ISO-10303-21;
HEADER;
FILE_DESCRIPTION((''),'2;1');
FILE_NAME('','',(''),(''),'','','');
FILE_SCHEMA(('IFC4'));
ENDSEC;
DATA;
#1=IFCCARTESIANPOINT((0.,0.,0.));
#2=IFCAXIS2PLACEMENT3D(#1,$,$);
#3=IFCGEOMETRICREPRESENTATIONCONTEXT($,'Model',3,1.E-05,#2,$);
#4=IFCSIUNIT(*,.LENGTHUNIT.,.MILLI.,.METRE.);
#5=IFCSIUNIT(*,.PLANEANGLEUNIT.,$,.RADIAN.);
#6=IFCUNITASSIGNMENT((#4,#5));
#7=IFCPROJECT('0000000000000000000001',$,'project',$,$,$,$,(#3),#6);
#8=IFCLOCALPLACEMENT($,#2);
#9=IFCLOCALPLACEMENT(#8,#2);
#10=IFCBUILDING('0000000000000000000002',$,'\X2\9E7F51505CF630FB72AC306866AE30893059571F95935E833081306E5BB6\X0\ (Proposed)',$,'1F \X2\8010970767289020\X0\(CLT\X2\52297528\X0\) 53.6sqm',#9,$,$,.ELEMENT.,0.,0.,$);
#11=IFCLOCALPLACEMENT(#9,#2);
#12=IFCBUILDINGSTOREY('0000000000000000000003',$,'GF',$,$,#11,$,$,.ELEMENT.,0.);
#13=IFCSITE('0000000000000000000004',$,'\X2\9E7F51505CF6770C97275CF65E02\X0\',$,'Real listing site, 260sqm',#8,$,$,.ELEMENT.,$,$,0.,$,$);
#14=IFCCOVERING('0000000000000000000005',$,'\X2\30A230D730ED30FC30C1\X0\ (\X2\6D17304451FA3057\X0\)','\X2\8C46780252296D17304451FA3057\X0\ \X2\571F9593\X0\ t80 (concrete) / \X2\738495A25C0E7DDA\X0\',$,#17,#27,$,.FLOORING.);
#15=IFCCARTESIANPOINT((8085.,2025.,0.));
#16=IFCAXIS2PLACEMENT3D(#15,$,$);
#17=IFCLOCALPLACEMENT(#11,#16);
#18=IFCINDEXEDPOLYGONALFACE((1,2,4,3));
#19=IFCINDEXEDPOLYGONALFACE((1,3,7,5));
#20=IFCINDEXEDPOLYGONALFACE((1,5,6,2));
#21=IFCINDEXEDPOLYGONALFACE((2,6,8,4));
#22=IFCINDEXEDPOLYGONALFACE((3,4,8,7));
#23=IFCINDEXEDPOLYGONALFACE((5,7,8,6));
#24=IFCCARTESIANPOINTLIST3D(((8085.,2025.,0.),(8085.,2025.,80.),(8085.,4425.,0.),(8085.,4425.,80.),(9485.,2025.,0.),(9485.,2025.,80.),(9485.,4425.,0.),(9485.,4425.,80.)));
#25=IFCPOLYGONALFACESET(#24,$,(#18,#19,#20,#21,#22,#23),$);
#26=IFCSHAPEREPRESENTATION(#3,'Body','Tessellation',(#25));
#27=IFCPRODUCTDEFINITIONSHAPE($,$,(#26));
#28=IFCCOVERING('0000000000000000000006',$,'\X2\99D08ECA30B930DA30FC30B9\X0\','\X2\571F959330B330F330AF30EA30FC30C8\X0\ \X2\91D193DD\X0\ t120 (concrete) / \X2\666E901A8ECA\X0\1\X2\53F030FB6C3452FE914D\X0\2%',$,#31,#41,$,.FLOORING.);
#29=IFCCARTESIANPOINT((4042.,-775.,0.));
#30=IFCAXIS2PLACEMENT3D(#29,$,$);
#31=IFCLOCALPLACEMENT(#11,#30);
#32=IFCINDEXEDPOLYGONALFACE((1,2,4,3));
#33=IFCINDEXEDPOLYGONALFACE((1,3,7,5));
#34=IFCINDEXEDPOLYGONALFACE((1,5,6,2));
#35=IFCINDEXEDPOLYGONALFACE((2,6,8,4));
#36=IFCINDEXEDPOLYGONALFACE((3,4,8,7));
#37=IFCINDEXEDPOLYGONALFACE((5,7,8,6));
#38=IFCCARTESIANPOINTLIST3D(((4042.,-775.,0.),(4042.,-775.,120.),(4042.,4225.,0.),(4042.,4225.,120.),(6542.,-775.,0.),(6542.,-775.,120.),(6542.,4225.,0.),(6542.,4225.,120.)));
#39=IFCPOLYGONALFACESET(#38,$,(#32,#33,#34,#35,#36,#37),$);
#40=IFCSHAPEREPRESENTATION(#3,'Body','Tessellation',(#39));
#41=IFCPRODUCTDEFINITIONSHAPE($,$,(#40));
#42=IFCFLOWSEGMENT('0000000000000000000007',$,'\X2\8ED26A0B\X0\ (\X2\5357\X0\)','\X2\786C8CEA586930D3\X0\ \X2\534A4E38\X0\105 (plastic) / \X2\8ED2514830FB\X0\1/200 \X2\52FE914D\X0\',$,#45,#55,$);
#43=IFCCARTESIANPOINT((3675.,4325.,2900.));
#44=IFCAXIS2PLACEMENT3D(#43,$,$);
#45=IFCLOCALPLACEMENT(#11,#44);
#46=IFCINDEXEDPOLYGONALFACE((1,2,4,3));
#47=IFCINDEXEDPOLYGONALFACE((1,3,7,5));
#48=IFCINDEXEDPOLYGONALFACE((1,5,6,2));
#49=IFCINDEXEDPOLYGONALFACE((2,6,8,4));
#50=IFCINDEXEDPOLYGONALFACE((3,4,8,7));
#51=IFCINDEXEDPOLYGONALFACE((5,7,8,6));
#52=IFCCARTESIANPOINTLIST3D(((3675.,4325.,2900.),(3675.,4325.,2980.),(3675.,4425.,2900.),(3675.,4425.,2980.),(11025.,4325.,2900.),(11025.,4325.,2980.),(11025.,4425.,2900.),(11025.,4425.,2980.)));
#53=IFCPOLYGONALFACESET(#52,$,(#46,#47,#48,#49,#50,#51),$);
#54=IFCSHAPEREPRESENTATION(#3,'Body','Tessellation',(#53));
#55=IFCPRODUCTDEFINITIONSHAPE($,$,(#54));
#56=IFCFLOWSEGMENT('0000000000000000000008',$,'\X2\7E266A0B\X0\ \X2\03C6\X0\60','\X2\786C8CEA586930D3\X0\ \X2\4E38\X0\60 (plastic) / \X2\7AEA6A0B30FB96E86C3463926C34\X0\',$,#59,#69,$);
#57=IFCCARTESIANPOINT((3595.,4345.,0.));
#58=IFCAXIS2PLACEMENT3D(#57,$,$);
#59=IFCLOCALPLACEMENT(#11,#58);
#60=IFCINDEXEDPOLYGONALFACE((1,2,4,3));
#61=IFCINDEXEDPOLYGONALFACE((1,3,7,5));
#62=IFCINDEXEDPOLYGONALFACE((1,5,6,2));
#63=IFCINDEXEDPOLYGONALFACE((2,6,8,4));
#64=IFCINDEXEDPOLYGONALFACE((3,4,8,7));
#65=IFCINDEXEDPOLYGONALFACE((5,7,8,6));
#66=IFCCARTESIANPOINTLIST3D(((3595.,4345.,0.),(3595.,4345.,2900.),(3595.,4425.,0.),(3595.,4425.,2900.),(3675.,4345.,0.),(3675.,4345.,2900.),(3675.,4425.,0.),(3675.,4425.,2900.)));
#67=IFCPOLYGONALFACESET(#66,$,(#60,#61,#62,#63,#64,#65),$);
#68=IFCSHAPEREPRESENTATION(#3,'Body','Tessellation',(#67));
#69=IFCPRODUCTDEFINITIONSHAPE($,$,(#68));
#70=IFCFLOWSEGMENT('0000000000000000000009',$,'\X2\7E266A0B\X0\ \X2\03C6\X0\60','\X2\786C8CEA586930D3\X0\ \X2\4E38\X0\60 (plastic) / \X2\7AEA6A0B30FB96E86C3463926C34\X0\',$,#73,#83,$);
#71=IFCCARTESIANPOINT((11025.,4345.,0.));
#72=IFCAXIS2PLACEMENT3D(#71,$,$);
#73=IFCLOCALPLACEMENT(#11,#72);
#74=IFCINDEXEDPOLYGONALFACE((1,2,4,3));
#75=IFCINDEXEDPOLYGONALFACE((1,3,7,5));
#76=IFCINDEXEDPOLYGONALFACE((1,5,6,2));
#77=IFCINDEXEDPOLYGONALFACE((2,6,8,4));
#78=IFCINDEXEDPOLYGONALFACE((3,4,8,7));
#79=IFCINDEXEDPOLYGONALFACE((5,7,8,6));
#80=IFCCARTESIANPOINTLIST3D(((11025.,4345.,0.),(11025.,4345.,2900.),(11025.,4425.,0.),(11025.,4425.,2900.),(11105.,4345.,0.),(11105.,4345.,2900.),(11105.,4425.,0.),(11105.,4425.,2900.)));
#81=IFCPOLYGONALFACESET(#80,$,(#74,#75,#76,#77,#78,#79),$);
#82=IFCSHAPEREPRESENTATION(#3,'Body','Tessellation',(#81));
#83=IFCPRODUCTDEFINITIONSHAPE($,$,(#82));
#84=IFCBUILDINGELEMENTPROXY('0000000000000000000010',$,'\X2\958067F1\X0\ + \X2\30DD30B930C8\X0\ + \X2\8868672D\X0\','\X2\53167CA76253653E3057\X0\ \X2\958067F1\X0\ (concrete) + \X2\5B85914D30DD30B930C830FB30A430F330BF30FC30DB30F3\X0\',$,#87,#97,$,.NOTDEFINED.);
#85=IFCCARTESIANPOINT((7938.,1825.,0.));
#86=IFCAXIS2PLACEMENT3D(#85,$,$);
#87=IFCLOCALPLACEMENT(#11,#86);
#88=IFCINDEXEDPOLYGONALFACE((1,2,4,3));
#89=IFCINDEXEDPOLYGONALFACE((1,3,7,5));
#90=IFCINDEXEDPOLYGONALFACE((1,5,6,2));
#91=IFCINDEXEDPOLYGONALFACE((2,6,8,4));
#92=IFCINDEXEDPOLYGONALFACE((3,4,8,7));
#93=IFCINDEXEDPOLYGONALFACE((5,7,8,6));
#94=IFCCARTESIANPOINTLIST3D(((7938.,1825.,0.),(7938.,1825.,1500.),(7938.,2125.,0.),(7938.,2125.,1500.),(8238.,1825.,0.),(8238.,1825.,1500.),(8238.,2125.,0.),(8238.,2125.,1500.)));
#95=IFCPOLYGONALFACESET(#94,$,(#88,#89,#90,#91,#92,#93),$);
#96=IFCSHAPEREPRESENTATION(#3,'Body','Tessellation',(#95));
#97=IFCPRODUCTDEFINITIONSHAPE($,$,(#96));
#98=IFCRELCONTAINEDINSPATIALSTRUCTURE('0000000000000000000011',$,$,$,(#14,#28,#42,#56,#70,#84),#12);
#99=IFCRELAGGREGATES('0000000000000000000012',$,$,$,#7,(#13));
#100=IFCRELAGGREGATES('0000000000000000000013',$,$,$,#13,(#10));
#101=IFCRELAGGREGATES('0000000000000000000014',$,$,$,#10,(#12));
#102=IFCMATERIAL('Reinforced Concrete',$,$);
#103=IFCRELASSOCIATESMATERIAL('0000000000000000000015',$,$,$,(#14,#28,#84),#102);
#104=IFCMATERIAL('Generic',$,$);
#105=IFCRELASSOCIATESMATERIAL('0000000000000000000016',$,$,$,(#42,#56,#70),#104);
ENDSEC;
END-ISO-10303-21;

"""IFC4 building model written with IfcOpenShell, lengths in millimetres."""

from ifc_helpers import new_model, si_unit, frame, frame_2d, origin, place, context, project, spatial, rectangle, extrude, material, element, save


model = new_model("IFC4")

# Units and contexts
model_context = context("Model", 3, precision=1e-05, world=origin())
ifc_project = project(units=[si_unit("LENGTHUNIT", "METRE", prefix="MILLI"), si_unit("PLANEANGLEUNIT", "RADIAN")], contexts=[model_context])

# Site, building, storey
site_placement = place(None, origin())
site = spatial("IfcSite", under=ifc_project, at=site_placement, Name="鹿児島県霧島市", ObjectType="Real listing site, 260sqm", CompositionType="ELEMENT", RefElevation=0.0)
building_placement = place(site_placement, origin())
building = spatial("IfcBuilding", under=site, at=building_placement, Name="鹿児島・犬と暮らす土間広めの家 (Proposed)", ObjectType="1F 耐震木造(CLT利用) 53.6sqm", CompositionType="ELEMENT", ElevationOfRefHeight=0.0, ElevationOfTerrain=0.0)
storey_placement = place(building_placement, origin())
storey = spatial("IfcBuildingStorey", under=building, at=storey_placement, Name="GF", CompositionType="ELEMENT", Elevation=0.0)

# Shared definitions
ifc_material_1 = material(Name="Reinforced Concrete")

# Coverings
ifc_material_2 = material(Name="Generic")
covering_1_placement = place(storey_placement, frame((8085.0, 2025.0, 0.0)))
element("IfcCovering", 1, at=covering_1_placement, inside=storey, material=ifc_material_1, Name="アプローチ (洗い出し)", Description="豆砂利洗い出し 土間 t80 (concrete) / 玄関導線", PredefinedType="FLOORING", context=model_context, shape_type="SweptSolid", body=[
    extrude(rectangle(XDim=1400.0, YDim=2400.0, at=frame_2d((700.0, 1200.0))), frame((8085.0, 2025.0, 0.0)), (0.0, 0.0, 1.0), 80.0),
])
covering_2_placement = place(storey_placement, frame((4042.0, -775.0, 0.0)))
element("IfcCovering", 2, at=covering_2_placement, inside=storey, material=ifc_material_1, Name="駐車スペース", Description="土間コンクリート 金鏝 t120 (concrete) / 普通車1台・水勾配2%", PredefinedType="FLOORING", context=model_context, shape_type="SweptSolid", body=[
    extrude(rectangle(XDim=2500.0, YDim=5000.0, at=frame_2d((1250.0, 2500.0))), frame((4042.0, -775.0, 0.0)), (0.0, 0.0, 1.0), 120.0),
])

# Flow segments
flow_segment_1_placement = place(storey_placement, frame((3675.0, 4325.0, 2900.0)))
element("IfcFlowSegment", 3, at=flow_segment_1_placement, inside=storey, material=ifc_material_2, Name="軒樋 (南)", Description="硬質塩ビ 半丸105 (plastic) / 軒先・1/200 勾配", context=model_context, shape_type="SweptSolid", body=[
    extrude(rectangle(XDim=7350.0, YDim=100.0, at=frame_2d((3675.0, 50.0))), frame((3675.0, 4325.0, 2900.0)), (0.0, 0.0, 1.0), 80.0),
])
flow_segment_2_placement = place(storey_placement, frame((3595.0, 4345.0, 0.0)))
element("IfcFlowSegment", 4, at=flow_segment_2_placement, inside=storey, material=ifc_material_2, Name="縦樋 φ60", Description="硬質塩ビ 丸60 (plastic) / 竪樋・雨水排水", context=model_context, shape_type="SweptSolid", body=[
    extrude(rectangle(XDim=80.0, YDim=80.0, at=frame_2d((40.0, 40.0))), frame((3595.0, 4345.0, 0.0)), (0.0, 0.0, 1.0), 2900.0),
])
flow_segment_3_placement = place(storey_placement, frame((11025.0, 4345.0, 0.0)))
element("IfcFlowSegment", 5, at=flow_segment_3_placement, inside=storey, material=ifc_material_2, Name="縦樋 φ60", Description="硬質塩ビ 丸60 (plastic) / 竪樋・雨水排水", context=model_context, shape_type="SweptSolid", body=[
    extrude(rectangle(XDim=80.0, YDim=80.0, at=frame_2d((40.0, 40.0))), frame((11025.0, 4345.0, 0.0)), (0.0, 0.0, 1.0), 2900.0),
])

# Building element proxy
proxy_placement = place(storey_placement, frame((7938.0, 1825.0, 0.0)))
element("IfcBuildingElementProxy", 6, at=proxy_placement, inside=storey, material=ifc_material_1, Name="門柱 + ポスト + 表札", Description="化粧打放し 門柱 (concrete) + 宅配ポスト・インターホン", PredefinedType="NOTDEFINED", context=model_context, shape_type="SweptSolid", body=[
    extrude(rectangle(XDim=300.0, YDim=300.0, at=frame_2d((150.0, 150.0))), frame((7938.0, 1825.0, 0.0)), (0.0, 0.0, 1.0), 1500.0),
])

save(model, "model.ifc")
